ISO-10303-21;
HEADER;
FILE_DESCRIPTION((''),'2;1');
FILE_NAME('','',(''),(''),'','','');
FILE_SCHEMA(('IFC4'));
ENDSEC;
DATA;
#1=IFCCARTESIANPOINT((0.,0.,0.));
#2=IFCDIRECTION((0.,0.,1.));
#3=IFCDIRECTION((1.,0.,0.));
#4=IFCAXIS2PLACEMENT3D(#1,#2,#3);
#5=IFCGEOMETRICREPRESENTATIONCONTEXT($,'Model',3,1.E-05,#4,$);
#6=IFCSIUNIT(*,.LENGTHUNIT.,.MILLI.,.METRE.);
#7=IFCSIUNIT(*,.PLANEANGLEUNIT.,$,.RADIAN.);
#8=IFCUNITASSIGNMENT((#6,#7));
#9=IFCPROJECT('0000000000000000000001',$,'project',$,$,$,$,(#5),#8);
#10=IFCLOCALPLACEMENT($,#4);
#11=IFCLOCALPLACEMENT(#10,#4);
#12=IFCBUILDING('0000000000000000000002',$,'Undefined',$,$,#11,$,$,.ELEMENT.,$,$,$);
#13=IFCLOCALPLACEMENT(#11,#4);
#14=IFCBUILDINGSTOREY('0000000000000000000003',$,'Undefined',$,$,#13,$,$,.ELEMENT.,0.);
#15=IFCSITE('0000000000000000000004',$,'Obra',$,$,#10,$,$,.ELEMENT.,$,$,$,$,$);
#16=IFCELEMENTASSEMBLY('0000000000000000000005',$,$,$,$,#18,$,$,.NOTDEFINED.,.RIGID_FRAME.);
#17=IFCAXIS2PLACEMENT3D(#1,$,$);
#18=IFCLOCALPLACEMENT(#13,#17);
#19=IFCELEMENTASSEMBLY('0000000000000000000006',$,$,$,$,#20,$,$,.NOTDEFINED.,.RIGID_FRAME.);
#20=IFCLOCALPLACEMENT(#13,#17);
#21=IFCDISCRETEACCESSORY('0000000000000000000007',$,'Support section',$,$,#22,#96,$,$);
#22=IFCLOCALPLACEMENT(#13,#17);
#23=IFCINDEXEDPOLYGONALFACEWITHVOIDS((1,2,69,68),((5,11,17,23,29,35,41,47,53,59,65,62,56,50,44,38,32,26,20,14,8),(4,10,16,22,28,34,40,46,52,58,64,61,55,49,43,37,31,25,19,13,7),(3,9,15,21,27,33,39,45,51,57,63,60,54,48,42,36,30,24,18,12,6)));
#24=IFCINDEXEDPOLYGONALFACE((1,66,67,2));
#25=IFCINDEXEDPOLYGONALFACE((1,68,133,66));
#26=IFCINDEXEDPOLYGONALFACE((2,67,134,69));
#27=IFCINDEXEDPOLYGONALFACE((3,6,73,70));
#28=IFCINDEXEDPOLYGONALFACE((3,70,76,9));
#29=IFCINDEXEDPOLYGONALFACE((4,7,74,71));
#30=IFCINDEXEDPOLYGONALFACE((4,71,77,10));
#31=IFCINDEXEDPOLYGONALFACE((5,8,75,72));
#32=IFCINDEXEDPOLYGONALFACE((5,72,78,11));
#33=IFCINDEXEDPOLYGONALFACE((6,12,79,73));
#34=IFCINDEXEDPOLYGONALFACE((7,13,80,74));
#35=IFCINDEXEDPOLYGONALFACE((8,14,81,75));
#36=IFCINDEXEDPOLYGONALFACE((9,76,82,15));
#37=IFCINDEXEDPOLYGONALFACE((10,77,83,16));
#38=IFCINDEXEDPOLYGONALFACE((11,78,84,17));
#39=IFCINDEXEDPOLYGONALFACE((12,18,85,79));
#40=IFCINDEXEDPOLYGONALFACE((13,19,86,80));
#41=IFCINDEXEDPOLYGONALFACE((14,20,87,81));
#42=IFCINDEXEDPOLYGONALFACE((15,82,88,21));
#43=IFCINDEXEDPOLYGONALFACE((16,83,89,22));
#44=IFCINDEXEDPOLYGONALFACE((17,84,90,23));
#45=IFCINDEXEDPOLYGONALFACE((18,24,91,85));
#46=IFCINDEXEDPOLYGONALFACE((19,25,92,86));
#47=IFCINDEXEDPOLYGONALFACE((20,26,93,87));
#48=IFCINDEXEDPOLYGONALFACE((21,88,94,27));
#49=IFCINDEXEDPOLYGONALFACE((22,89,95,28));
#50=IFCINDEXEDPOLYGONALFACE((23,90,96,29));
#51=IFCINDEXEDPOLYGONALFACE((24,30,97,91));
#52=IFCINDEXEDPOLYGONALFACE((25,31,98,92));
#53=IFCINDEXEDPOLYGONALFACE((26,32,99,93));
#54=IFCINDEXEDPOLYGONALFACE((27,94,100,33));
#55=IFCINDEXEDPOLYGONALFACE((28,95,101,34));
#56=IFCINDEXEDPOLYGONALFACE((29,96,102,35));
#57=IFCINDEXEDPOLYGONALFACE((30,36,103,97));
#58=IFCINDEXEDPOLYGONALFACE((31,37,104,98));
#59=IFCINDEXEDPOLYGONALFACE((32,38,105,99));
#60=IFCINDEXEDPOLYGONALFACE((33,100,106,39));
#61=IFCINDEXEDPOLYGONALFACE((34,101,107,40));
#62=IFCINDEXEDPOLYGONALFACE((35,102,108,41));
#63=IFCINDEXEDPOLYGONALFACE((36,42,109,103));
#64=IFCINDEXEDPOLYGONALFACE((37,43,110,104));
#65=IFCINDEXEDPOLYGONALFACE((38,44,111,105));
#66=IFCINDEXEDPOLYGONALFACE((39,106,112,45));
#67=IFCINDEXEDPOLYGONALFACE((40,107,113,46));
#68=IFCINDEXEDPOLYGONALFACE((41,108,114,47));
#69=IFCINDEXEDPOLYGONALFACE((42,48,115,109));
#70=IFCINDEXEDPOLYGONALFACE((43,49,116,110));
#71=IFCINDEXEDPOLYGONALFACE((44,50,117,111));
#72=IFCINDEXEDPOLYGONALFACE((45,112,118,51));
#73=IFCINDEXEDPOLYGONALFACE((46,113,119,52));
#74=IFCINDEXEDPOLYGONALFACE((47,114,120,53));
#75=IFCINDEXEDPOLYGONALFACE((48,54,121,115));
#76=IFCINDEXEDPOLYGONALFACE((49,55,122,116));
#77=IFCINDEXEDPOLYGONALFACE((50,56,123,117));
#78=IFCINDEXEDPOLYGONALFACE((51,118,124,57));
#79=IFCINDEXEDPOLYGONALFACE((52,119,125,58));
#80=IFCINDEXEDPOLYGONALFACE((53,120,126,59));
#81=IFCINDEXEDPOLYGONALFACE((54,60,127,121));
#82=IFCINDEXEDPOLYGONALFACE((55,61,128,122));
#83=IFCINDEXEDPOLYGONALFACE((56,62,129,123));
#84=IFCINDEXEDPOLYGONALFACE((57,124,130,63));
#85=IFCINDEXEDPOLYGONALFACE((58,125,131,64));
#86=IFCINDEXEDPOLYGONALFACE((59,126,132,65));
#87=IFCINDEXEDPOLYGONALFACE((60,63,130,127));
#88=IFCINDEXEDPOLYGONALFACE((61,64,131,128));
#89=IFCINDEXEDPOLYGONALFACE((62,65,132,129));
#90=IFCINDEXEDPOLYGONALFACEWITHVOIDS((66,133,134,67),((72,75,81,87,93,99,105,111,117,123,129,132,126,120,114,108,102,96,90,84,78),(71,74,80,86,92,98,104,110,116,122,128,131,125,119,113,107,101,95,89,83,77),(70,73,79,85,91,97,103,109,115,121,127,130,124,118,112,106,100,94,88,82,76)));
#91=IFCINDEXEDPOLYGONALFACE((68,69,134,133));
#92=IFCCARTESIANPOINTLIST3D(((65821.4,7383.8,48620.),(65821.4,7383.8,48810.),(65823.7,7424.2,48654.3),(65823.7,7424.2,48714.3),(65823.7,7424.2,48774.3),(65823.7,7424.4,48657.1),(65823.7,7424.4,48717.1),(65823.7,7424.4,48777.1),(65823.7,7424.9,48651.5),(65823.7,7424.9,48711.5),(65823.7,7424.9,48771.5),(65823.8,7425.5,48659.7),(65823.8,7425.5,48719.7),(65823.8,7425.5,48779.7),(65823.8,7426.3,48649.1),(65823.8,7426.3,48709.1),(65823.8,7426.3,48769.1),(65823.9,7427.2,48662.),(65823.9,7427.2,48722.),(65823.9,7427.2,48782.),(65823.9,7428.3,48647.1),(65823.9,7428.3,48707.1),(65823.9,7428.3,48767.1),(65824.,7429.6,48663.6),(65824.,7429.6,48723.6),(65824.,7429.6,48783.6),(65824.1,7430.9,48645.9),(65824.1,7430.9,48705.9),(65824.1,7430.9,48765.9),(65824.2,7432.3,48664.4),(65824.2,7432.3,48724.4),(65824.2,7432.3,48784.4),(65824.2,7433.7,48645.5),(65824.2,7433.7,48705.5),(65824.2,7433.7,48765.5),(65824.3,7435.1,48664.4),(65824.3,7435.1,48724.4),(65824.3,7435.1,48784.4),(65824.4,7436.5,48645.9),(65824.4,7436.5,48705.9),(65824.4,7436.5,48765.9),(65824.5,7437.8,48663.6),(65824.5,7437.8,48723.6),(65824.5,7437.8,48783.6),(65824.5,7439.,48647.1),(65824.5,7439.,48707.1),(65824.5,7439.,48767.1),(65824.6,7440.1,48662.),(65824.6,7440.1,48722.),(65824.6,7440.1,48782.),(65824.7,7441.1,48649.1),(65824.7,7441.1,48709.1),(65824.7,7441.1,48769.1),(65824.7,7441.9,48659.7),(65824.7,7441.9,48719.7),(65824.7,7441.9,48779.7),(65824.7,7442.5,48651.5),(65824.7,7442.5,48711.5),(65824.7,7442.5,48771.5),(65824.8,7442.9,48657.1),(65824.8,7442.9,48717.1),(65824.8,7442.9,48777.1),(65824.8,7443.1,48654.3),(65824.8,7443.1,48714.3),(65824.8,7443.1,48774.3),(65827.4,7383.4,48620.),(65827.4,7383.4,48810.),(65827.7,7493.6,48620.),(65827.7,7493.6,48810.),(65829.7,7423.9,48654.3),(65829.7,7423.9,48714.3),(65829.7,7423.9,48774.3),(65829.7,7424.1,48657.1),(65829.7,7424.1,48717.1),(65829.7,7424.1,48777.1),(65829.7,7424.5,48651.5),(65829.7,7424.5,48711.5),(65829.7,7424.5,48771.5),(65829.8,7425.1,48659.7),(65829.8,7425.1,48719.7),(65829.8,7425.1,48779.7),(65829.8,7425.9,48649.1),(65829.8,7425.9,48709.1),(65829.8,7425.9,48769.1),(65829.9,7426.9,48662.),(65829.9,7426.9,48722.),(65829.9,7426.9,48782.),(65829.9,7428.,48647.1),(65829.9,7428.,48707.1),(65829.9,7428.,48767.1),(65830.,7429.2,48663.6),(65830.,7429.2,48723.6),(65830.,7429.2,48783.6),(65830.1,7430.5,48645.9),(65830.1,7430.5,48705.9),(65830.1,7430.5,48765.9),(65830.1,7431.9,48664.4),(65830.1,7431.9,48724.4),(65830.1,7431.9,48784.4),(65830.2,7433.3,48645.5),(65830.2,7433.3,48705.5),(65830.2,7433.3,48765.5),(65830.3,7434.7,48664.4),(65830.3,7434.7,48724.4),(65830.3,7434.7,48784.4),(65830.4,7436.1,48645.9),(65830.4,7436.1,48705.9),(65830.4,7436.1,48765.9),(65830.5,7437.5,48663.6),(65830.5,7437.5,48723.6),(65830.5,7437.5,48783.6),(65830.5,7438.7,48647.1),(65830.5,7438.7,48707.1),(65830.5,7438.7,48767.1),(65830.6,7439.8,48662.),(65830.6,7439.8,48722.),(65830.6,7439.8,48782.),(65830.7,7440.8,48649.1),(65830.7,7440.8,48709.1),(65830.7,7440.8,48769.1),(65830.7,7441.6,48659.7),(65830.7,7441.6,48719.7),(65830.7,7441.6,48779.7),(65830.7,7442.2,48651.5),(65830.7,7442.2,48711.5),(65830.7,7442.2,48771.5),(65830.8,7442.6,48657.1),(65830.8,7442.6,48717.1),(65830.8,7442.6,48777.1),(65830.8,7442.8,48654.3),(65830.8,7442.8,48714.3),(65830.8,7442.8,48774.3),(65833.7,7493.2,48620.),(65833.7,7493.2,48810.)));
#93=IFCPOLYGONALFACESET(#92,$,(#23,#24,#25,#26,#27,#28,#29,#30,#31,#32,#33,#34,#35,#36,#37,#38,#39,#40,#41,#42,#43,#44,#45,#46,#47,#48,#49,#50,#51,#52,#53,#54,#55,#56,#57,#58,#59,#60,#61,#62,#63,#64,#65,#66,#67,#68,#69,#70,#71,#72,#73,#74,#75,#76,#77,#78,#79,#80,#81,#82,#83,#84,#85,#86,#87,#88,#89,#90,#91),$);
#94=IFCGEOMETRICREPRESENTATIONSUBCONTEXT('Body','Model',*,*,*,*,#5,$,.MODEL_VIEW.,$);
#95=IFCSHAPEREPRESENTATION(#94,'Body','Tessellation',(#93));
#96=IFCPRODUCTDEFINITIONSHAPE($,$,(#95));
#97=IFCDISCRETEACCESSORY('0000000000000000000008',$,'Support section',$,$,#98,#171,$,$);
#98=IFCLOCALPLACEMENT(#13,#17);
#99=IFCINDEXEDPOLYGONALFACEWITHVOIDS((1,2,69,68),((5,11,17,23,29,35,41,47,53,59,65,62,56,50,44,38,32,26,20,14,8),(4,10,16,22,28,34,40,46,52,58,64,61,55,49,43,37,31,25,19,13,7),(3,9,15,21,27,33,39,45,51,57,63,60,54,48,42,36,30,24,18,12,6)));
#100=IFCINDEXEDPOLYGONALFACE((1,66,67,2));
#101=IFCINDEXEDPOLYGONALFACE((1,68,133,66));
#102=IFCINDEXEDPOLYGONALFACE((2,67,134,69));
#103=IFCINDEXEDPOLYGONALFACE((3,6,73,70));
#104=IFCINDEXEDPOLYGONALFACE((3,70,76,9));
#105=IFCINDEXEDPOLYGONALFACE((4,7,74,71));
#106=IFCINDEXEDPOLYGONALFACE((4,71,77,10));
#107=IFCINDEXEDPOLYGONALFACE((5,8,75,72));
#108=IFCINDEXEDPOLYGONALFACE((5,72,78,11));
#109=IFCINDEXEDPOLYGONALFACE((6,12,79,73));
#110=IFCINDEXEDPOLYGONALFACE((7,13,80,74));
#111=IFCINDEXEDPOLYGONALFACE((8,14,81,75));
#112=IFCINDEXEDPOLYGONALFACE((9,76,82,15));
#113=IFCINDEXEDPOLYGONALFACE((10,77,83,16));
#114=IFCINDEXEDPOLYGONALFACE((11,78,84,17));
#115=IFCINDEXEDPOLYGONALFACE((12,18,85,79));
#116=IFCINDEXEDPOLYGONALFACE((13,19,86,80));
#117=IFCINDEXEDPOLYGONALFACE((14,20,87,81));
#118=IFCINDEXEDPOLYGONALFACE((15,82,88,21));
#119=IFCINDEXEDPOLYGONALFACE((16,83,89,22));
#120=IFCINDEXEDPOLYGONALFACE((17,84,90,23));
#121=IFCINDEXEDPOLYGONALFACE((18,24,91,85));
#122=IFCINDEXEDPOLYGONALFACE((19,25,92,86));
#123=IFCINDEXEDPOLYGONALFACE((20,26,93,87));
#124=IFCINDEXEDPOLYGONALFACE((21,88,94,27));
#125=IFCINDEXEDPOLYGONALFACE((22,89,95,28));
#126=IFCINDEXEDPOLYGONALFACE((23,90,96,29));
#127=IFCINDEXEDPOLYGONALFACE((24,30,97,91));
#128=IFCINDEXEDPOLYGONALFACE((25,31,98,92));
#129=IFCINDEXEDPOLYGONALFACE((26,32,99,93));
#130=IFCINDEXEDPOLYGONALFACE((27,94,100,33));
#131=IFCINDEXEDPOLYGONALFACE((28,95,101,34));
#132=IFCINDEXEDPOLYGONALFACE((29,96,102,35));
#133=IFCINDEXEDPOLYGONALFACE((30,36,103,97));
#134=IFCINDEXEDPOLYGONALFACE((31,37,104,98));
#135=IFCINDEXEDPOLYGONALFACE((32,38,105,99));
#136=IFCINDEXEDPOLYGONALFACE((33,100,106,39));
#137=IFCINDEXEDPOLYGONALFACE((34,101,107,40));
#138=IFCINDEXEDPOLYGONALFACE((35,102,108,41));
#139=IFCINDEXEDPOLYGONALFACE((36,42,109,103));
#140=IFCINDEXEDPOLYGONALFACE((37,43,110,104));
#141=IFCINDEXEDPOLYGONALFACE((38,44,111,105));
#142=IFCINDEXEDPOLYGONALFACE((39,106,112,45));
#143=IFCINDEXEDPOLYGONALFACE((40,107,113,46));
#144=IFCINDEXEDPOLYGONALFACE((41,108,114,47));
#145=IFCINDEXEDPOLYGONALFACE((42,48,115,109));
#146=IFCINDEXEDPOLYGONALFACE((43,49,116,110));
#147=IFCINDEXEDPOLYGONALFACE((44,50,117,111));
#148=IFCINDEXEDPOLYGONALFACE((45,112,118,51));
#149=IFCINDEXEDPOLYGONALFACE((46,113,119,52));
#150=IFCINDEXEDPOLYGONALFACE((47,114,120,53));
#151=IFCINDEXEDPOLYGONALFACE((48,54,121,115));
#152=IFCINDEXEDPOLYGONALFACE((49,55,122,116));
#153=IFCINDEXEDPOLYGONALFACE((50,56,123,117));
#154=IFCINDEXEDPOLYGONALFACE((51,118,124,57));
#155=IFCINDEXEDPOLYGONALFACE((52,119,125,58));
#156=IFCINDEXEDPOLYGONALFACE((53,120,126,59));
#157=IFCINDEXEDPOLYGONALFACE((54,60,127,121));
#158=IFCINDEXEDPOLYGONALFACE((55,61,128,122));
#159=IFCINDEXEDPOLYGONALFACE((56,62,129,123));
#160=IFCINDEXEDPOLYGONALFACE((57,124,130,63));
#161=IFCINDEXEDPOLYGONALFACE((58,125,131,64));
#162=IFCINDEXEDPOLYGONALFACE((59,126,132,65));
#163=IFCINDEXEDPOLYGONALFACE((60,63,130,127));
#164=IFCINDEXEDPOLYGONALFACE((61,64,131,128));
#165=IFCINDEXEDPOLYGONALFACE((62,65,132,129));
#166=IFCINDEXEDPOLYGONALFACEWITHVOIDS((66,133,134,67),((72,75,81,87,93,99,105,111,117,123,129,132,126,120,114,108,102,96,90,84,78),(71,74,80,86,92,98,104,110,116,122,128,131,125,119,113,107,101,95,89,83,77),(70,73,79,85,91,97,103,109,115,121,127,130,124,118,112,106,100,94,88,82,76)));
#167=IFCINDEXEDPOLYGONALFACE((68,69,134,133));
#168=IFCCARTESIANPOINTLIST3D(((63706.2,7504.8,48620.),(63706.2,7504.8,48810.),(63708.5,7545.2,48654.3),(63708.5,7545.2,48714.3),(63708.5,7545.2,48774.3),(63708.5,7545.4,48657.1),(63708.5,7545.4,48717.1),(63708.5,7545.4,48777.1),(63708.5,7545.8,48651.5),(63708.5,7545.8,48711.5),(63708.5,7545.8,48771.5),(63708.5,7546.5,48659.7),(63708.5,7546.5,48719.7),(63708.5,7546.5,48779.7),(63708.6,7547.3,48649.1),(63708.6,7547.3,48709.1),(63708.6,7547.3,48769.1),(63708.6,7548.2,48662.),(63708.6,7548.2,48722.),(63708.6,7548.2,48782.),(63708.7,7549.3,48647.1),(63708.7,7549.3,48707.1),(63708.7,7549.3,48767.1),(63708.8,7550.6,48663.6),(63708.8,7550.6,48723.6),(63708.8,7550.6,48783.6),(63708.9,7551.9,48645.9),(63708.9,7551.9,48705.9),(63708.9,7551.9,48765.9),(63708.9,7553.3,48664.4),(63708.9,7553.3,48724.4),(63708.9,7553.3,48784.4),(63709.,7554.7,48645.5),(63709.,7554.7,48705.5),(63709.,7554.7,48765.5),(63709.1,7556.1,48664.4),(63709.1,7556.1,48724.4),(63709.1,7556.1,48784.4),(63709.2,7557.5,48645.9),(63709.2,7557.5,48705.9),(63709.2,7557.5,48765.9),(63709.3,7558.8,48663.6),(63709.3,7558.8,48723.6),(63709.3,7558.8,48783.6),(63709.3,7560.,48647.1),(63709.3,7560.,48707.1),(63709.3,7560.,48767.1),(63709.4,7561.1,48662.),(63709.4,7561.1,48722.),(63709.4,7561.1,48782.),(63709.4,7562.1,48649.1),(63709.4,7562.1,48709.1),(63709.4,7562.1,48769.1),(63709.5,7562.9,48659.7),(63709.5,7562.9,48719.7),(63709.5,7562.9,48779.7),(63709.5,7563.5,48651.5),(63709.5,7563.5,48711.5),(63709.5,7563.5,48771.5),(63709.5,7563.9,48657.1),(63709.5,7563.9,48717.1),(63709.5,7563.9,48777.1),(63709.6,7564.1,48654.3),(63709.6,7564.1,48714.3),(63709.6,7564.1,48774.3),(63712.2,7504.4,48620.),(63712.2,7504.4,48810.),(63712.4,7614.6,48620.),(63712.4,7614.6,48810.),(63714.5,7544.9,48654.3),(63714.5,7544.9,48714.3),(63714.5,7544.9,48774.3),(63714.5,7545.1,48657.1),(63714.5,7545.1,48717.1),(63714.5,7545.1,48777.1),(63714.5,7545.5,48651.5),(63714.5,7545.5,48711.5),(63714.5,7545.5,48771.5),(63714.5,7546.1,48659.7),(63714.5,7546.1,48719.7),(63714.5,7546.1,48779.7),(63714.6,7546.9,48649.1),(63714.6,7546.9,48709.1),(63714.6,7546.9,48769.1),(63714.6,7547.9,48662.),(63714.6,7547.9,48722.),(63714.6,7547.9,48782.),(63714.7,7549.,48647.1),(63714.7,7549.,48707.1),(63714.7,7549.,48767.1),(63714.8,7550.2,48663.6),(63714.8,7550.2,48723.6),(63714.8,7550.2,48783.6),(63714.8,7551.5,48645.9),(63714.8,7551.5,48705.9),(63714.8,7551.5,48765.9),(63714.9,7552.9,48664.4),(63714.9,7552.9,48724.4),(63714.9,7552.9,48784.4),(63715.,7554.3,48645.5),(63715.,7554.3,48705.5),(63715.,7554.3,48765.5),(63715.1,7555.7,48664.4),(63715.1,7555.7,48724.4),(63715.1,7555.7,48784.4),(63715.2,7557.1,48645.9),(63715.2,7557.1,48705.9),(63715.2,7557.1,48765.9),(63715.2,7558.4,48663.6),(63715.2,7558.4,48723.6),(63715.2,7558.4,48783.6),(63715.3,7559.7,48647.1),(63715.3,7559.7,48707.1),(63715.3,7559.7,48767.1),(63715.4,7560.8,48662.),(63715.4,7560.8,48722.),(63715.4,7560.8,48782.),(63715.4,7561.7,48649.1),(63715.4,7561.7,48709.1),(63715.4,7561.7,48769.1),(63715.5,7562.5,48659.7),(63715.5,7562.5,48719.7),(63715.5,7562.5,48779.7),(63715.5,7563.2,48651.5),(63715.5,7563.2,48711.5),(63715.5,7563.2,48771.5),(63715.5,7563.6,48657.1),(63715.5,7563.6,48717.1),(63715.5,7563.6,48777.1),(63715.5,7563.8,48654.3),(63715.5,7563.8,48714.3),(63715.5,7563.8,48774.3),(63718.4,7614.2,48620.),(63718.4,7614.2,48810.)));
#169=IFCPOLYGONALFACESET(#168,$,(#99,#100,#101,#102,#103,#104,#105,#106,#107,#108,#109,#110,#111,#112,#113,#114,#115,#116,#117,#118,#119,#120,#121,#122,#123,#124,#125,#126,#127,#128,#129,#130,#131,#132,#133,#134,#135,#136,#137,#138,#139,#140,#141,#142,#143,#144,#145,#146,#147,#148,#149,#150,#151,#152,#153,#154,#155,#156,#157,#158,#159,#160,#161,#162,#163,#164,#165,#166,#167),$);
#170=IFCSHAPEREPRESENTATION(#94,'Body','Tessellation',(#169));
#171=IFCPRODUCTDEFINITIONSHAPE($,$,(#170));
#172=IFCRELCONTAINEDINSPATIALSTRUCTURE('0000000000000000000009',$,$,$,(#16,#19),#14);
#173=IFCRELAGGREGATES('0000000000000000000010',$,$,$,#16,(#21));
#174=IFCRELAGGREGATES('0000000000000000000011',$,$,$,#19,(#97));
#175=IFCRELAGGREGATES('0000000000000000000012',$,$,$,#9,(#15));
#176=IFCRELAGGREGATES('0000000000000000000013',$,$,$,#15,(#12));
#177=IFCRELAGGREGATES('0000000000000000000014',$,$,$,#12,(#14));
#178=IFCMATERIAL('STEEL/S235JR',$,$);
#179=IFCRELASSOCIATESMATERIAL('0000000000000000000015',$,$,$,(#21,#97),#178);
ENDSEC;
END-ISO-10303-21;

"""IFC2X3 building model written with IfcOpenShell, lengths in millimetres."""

from ifc_helpers import new_model, si_unit, frame, origin_with_axes, origin_2d_with_axis, place, context, subcontext, project, spatial, rectangle, circle, extrude, source, transform, mapped, material, element, aggregate, save


model = new_model("IFC2X3")

# Units and contexts
model_context = context("Model", 3, precision=1e-05, world=origin_with_axes())
body_context = subcontext(model_context, "Body", "Model", "MODEL_VIEW")
ifc_project = project(units=[si_unit("LENGTHUNIT", "METRE", prefix="MILLI"), si_unit("PLANEANGLEUNIT", "RADIAN")], contexts=[model_context])

# Site, building, storey
site_placement = place(None, origin_with_axes())
site = spatial("IfcSite", under=ifc_project, at=site_placement, Name="Obra", CompositionType="ELEMENT")
building_placement = place(site_placement, origin_with_axes())
building = spatial("IfcBuilding", under=site, at=building_placement, Name="Undefined", CompositionType="ELEMENT")
storey_placement = place(building_placement, origin_with_axes())
storey = spatial("IfcBuildingStorey", under=building, at=storey_placement, Name="Undefined", CompositionType="ELEMENT", Elevation=0.0)

# Element assemblies
assembly_1_placement = place(storey_placement, origin_with_axes())
assembly_1 = element("IfcElementAssembly", 1, at=assembly_1_placement, inside=storey, AssemblyPlace="NOTDEFINED", PredefinedType="RIGID_FRAME")
ifc_material_1 = material(Name="STEEL/S235JR")
assembly_2_placement = place(storey_placement, origin_with_axes())
assembly_2 = element("IfcElementAssembly", 2, at=assembly_2_placement, inside=storey, AssemblyPlace="NOTDEFINED", PredefinedType="RIGID_FRAME")

# Discrete accessories, openings
discrete_accessory_1_placement = place(assembly_1_placement, frame((65827.5, 7438.5, 48620.0), z_axis=(0.0, 0.0, 1.0), x_axis=(0.05711, 0.998368, 0.0)))
discrete_accessory_1 = element("IfcDiscreteAccessory", 3, at=discrete_accessory_1_placement, material=ifc_material_1, Name="Support section", context=body_context, shape_type="SweptSolid", body=[
    extrude(rectangle(XDim=6.0, YDim=110.0, at=origin_2d_with_axis()), frame((0.0, 0.0, 190.0), z_axis=(0.0, 0.0, -1.0), x_axis=(0.0, 1.0, 0.0)), (0.0, 0.0, 1.0), 190.0),
])
shared_shape_1 = source(origin_with_axes(), body_context, "Body", "SweptSolid", [
    extrude(circle(Radius=9.5, at=origin_2d_with_axis()), frame((0.0, -9.2, 0.0), z_axis=(0.0, 1.0, 0.0), x_axis=(1.0, 0.0, 0.0)), (0.0, 0.0, 1.0), 6.2),
])
opening_1_placement = place(assembly_1_placement, frame((65836.2, 7483.1, 48835.0), z_axis=(-0.05711, -0.998368, 0.0), x_axis=(0.0, 0.0, -1.0)))
element("IfcOpeningElement", 4, at=opening_1_placement, cuts=discrete_accessory_1, ObjectType="Opening", context=body_context, shape_type="MappedRepresentation", body=[
    mapped(shared_shape_1, transform((60.0, 0.0, 50.0))),
    mapped(shared_shape_1, transform((120.0, 0.0, 50.0))),
    mapped(shared_shape_1, transform((180.0, 0.0, 50.0))),
])
aggregate(assembly_1, [discrete_accessory_1])
discrete_accessory_2_placement = place(assembly_2_placement, frame((63712.3, 7559.5, 48620.0), z_axis=(0.0, 0.0, 1.0), x_axis=(0.05711, 0.998368, 0.0)))
discrete_accessory_2 = element("IfcDiscreteAccessory", 5, at=discrete_accessory_2_placement, material=ifc_material_1, Name="Support section", context=body_context, shape_type="SweptSolid", body=[
    extrude(rectangle(XDim=6.0, YDim=110.0, at=origin_2d_with_axis()), frame((0.0, 0.0, 190.0), z_axis=(0.0, 0.0, -1.0), x_axis=(0.0, 1.0, 0.0)), (0.0, 0.0, 1.0), 190.0),
])
opening_2_placement = place(assembly_2_placement, frame((63721.0, 7604.1, 48835.0), z_axis=(-0.05711, -0.998368, 0.0), x_axis=(0.0, 0.0, -1.0)))
element("IfcOpeningElement", 6, at=opening_2_placement, cuts=discrete_accessory_2, ObjectType="Opening", context=body_context, shape_type="MappedRepresentation", body=[
    mapped(shared_shape_1, transform((60.0, 0.0, 50.0))),
    mapped(shared_shape_1, transform((120.0, 0.0, 50.0))),
    mapped(shared_shape_1, transform((180.0, 0.0, 50.0))),
])
aggregate(assembly_2, [discrete_accessory_2])

save(model, "model.ifc")
